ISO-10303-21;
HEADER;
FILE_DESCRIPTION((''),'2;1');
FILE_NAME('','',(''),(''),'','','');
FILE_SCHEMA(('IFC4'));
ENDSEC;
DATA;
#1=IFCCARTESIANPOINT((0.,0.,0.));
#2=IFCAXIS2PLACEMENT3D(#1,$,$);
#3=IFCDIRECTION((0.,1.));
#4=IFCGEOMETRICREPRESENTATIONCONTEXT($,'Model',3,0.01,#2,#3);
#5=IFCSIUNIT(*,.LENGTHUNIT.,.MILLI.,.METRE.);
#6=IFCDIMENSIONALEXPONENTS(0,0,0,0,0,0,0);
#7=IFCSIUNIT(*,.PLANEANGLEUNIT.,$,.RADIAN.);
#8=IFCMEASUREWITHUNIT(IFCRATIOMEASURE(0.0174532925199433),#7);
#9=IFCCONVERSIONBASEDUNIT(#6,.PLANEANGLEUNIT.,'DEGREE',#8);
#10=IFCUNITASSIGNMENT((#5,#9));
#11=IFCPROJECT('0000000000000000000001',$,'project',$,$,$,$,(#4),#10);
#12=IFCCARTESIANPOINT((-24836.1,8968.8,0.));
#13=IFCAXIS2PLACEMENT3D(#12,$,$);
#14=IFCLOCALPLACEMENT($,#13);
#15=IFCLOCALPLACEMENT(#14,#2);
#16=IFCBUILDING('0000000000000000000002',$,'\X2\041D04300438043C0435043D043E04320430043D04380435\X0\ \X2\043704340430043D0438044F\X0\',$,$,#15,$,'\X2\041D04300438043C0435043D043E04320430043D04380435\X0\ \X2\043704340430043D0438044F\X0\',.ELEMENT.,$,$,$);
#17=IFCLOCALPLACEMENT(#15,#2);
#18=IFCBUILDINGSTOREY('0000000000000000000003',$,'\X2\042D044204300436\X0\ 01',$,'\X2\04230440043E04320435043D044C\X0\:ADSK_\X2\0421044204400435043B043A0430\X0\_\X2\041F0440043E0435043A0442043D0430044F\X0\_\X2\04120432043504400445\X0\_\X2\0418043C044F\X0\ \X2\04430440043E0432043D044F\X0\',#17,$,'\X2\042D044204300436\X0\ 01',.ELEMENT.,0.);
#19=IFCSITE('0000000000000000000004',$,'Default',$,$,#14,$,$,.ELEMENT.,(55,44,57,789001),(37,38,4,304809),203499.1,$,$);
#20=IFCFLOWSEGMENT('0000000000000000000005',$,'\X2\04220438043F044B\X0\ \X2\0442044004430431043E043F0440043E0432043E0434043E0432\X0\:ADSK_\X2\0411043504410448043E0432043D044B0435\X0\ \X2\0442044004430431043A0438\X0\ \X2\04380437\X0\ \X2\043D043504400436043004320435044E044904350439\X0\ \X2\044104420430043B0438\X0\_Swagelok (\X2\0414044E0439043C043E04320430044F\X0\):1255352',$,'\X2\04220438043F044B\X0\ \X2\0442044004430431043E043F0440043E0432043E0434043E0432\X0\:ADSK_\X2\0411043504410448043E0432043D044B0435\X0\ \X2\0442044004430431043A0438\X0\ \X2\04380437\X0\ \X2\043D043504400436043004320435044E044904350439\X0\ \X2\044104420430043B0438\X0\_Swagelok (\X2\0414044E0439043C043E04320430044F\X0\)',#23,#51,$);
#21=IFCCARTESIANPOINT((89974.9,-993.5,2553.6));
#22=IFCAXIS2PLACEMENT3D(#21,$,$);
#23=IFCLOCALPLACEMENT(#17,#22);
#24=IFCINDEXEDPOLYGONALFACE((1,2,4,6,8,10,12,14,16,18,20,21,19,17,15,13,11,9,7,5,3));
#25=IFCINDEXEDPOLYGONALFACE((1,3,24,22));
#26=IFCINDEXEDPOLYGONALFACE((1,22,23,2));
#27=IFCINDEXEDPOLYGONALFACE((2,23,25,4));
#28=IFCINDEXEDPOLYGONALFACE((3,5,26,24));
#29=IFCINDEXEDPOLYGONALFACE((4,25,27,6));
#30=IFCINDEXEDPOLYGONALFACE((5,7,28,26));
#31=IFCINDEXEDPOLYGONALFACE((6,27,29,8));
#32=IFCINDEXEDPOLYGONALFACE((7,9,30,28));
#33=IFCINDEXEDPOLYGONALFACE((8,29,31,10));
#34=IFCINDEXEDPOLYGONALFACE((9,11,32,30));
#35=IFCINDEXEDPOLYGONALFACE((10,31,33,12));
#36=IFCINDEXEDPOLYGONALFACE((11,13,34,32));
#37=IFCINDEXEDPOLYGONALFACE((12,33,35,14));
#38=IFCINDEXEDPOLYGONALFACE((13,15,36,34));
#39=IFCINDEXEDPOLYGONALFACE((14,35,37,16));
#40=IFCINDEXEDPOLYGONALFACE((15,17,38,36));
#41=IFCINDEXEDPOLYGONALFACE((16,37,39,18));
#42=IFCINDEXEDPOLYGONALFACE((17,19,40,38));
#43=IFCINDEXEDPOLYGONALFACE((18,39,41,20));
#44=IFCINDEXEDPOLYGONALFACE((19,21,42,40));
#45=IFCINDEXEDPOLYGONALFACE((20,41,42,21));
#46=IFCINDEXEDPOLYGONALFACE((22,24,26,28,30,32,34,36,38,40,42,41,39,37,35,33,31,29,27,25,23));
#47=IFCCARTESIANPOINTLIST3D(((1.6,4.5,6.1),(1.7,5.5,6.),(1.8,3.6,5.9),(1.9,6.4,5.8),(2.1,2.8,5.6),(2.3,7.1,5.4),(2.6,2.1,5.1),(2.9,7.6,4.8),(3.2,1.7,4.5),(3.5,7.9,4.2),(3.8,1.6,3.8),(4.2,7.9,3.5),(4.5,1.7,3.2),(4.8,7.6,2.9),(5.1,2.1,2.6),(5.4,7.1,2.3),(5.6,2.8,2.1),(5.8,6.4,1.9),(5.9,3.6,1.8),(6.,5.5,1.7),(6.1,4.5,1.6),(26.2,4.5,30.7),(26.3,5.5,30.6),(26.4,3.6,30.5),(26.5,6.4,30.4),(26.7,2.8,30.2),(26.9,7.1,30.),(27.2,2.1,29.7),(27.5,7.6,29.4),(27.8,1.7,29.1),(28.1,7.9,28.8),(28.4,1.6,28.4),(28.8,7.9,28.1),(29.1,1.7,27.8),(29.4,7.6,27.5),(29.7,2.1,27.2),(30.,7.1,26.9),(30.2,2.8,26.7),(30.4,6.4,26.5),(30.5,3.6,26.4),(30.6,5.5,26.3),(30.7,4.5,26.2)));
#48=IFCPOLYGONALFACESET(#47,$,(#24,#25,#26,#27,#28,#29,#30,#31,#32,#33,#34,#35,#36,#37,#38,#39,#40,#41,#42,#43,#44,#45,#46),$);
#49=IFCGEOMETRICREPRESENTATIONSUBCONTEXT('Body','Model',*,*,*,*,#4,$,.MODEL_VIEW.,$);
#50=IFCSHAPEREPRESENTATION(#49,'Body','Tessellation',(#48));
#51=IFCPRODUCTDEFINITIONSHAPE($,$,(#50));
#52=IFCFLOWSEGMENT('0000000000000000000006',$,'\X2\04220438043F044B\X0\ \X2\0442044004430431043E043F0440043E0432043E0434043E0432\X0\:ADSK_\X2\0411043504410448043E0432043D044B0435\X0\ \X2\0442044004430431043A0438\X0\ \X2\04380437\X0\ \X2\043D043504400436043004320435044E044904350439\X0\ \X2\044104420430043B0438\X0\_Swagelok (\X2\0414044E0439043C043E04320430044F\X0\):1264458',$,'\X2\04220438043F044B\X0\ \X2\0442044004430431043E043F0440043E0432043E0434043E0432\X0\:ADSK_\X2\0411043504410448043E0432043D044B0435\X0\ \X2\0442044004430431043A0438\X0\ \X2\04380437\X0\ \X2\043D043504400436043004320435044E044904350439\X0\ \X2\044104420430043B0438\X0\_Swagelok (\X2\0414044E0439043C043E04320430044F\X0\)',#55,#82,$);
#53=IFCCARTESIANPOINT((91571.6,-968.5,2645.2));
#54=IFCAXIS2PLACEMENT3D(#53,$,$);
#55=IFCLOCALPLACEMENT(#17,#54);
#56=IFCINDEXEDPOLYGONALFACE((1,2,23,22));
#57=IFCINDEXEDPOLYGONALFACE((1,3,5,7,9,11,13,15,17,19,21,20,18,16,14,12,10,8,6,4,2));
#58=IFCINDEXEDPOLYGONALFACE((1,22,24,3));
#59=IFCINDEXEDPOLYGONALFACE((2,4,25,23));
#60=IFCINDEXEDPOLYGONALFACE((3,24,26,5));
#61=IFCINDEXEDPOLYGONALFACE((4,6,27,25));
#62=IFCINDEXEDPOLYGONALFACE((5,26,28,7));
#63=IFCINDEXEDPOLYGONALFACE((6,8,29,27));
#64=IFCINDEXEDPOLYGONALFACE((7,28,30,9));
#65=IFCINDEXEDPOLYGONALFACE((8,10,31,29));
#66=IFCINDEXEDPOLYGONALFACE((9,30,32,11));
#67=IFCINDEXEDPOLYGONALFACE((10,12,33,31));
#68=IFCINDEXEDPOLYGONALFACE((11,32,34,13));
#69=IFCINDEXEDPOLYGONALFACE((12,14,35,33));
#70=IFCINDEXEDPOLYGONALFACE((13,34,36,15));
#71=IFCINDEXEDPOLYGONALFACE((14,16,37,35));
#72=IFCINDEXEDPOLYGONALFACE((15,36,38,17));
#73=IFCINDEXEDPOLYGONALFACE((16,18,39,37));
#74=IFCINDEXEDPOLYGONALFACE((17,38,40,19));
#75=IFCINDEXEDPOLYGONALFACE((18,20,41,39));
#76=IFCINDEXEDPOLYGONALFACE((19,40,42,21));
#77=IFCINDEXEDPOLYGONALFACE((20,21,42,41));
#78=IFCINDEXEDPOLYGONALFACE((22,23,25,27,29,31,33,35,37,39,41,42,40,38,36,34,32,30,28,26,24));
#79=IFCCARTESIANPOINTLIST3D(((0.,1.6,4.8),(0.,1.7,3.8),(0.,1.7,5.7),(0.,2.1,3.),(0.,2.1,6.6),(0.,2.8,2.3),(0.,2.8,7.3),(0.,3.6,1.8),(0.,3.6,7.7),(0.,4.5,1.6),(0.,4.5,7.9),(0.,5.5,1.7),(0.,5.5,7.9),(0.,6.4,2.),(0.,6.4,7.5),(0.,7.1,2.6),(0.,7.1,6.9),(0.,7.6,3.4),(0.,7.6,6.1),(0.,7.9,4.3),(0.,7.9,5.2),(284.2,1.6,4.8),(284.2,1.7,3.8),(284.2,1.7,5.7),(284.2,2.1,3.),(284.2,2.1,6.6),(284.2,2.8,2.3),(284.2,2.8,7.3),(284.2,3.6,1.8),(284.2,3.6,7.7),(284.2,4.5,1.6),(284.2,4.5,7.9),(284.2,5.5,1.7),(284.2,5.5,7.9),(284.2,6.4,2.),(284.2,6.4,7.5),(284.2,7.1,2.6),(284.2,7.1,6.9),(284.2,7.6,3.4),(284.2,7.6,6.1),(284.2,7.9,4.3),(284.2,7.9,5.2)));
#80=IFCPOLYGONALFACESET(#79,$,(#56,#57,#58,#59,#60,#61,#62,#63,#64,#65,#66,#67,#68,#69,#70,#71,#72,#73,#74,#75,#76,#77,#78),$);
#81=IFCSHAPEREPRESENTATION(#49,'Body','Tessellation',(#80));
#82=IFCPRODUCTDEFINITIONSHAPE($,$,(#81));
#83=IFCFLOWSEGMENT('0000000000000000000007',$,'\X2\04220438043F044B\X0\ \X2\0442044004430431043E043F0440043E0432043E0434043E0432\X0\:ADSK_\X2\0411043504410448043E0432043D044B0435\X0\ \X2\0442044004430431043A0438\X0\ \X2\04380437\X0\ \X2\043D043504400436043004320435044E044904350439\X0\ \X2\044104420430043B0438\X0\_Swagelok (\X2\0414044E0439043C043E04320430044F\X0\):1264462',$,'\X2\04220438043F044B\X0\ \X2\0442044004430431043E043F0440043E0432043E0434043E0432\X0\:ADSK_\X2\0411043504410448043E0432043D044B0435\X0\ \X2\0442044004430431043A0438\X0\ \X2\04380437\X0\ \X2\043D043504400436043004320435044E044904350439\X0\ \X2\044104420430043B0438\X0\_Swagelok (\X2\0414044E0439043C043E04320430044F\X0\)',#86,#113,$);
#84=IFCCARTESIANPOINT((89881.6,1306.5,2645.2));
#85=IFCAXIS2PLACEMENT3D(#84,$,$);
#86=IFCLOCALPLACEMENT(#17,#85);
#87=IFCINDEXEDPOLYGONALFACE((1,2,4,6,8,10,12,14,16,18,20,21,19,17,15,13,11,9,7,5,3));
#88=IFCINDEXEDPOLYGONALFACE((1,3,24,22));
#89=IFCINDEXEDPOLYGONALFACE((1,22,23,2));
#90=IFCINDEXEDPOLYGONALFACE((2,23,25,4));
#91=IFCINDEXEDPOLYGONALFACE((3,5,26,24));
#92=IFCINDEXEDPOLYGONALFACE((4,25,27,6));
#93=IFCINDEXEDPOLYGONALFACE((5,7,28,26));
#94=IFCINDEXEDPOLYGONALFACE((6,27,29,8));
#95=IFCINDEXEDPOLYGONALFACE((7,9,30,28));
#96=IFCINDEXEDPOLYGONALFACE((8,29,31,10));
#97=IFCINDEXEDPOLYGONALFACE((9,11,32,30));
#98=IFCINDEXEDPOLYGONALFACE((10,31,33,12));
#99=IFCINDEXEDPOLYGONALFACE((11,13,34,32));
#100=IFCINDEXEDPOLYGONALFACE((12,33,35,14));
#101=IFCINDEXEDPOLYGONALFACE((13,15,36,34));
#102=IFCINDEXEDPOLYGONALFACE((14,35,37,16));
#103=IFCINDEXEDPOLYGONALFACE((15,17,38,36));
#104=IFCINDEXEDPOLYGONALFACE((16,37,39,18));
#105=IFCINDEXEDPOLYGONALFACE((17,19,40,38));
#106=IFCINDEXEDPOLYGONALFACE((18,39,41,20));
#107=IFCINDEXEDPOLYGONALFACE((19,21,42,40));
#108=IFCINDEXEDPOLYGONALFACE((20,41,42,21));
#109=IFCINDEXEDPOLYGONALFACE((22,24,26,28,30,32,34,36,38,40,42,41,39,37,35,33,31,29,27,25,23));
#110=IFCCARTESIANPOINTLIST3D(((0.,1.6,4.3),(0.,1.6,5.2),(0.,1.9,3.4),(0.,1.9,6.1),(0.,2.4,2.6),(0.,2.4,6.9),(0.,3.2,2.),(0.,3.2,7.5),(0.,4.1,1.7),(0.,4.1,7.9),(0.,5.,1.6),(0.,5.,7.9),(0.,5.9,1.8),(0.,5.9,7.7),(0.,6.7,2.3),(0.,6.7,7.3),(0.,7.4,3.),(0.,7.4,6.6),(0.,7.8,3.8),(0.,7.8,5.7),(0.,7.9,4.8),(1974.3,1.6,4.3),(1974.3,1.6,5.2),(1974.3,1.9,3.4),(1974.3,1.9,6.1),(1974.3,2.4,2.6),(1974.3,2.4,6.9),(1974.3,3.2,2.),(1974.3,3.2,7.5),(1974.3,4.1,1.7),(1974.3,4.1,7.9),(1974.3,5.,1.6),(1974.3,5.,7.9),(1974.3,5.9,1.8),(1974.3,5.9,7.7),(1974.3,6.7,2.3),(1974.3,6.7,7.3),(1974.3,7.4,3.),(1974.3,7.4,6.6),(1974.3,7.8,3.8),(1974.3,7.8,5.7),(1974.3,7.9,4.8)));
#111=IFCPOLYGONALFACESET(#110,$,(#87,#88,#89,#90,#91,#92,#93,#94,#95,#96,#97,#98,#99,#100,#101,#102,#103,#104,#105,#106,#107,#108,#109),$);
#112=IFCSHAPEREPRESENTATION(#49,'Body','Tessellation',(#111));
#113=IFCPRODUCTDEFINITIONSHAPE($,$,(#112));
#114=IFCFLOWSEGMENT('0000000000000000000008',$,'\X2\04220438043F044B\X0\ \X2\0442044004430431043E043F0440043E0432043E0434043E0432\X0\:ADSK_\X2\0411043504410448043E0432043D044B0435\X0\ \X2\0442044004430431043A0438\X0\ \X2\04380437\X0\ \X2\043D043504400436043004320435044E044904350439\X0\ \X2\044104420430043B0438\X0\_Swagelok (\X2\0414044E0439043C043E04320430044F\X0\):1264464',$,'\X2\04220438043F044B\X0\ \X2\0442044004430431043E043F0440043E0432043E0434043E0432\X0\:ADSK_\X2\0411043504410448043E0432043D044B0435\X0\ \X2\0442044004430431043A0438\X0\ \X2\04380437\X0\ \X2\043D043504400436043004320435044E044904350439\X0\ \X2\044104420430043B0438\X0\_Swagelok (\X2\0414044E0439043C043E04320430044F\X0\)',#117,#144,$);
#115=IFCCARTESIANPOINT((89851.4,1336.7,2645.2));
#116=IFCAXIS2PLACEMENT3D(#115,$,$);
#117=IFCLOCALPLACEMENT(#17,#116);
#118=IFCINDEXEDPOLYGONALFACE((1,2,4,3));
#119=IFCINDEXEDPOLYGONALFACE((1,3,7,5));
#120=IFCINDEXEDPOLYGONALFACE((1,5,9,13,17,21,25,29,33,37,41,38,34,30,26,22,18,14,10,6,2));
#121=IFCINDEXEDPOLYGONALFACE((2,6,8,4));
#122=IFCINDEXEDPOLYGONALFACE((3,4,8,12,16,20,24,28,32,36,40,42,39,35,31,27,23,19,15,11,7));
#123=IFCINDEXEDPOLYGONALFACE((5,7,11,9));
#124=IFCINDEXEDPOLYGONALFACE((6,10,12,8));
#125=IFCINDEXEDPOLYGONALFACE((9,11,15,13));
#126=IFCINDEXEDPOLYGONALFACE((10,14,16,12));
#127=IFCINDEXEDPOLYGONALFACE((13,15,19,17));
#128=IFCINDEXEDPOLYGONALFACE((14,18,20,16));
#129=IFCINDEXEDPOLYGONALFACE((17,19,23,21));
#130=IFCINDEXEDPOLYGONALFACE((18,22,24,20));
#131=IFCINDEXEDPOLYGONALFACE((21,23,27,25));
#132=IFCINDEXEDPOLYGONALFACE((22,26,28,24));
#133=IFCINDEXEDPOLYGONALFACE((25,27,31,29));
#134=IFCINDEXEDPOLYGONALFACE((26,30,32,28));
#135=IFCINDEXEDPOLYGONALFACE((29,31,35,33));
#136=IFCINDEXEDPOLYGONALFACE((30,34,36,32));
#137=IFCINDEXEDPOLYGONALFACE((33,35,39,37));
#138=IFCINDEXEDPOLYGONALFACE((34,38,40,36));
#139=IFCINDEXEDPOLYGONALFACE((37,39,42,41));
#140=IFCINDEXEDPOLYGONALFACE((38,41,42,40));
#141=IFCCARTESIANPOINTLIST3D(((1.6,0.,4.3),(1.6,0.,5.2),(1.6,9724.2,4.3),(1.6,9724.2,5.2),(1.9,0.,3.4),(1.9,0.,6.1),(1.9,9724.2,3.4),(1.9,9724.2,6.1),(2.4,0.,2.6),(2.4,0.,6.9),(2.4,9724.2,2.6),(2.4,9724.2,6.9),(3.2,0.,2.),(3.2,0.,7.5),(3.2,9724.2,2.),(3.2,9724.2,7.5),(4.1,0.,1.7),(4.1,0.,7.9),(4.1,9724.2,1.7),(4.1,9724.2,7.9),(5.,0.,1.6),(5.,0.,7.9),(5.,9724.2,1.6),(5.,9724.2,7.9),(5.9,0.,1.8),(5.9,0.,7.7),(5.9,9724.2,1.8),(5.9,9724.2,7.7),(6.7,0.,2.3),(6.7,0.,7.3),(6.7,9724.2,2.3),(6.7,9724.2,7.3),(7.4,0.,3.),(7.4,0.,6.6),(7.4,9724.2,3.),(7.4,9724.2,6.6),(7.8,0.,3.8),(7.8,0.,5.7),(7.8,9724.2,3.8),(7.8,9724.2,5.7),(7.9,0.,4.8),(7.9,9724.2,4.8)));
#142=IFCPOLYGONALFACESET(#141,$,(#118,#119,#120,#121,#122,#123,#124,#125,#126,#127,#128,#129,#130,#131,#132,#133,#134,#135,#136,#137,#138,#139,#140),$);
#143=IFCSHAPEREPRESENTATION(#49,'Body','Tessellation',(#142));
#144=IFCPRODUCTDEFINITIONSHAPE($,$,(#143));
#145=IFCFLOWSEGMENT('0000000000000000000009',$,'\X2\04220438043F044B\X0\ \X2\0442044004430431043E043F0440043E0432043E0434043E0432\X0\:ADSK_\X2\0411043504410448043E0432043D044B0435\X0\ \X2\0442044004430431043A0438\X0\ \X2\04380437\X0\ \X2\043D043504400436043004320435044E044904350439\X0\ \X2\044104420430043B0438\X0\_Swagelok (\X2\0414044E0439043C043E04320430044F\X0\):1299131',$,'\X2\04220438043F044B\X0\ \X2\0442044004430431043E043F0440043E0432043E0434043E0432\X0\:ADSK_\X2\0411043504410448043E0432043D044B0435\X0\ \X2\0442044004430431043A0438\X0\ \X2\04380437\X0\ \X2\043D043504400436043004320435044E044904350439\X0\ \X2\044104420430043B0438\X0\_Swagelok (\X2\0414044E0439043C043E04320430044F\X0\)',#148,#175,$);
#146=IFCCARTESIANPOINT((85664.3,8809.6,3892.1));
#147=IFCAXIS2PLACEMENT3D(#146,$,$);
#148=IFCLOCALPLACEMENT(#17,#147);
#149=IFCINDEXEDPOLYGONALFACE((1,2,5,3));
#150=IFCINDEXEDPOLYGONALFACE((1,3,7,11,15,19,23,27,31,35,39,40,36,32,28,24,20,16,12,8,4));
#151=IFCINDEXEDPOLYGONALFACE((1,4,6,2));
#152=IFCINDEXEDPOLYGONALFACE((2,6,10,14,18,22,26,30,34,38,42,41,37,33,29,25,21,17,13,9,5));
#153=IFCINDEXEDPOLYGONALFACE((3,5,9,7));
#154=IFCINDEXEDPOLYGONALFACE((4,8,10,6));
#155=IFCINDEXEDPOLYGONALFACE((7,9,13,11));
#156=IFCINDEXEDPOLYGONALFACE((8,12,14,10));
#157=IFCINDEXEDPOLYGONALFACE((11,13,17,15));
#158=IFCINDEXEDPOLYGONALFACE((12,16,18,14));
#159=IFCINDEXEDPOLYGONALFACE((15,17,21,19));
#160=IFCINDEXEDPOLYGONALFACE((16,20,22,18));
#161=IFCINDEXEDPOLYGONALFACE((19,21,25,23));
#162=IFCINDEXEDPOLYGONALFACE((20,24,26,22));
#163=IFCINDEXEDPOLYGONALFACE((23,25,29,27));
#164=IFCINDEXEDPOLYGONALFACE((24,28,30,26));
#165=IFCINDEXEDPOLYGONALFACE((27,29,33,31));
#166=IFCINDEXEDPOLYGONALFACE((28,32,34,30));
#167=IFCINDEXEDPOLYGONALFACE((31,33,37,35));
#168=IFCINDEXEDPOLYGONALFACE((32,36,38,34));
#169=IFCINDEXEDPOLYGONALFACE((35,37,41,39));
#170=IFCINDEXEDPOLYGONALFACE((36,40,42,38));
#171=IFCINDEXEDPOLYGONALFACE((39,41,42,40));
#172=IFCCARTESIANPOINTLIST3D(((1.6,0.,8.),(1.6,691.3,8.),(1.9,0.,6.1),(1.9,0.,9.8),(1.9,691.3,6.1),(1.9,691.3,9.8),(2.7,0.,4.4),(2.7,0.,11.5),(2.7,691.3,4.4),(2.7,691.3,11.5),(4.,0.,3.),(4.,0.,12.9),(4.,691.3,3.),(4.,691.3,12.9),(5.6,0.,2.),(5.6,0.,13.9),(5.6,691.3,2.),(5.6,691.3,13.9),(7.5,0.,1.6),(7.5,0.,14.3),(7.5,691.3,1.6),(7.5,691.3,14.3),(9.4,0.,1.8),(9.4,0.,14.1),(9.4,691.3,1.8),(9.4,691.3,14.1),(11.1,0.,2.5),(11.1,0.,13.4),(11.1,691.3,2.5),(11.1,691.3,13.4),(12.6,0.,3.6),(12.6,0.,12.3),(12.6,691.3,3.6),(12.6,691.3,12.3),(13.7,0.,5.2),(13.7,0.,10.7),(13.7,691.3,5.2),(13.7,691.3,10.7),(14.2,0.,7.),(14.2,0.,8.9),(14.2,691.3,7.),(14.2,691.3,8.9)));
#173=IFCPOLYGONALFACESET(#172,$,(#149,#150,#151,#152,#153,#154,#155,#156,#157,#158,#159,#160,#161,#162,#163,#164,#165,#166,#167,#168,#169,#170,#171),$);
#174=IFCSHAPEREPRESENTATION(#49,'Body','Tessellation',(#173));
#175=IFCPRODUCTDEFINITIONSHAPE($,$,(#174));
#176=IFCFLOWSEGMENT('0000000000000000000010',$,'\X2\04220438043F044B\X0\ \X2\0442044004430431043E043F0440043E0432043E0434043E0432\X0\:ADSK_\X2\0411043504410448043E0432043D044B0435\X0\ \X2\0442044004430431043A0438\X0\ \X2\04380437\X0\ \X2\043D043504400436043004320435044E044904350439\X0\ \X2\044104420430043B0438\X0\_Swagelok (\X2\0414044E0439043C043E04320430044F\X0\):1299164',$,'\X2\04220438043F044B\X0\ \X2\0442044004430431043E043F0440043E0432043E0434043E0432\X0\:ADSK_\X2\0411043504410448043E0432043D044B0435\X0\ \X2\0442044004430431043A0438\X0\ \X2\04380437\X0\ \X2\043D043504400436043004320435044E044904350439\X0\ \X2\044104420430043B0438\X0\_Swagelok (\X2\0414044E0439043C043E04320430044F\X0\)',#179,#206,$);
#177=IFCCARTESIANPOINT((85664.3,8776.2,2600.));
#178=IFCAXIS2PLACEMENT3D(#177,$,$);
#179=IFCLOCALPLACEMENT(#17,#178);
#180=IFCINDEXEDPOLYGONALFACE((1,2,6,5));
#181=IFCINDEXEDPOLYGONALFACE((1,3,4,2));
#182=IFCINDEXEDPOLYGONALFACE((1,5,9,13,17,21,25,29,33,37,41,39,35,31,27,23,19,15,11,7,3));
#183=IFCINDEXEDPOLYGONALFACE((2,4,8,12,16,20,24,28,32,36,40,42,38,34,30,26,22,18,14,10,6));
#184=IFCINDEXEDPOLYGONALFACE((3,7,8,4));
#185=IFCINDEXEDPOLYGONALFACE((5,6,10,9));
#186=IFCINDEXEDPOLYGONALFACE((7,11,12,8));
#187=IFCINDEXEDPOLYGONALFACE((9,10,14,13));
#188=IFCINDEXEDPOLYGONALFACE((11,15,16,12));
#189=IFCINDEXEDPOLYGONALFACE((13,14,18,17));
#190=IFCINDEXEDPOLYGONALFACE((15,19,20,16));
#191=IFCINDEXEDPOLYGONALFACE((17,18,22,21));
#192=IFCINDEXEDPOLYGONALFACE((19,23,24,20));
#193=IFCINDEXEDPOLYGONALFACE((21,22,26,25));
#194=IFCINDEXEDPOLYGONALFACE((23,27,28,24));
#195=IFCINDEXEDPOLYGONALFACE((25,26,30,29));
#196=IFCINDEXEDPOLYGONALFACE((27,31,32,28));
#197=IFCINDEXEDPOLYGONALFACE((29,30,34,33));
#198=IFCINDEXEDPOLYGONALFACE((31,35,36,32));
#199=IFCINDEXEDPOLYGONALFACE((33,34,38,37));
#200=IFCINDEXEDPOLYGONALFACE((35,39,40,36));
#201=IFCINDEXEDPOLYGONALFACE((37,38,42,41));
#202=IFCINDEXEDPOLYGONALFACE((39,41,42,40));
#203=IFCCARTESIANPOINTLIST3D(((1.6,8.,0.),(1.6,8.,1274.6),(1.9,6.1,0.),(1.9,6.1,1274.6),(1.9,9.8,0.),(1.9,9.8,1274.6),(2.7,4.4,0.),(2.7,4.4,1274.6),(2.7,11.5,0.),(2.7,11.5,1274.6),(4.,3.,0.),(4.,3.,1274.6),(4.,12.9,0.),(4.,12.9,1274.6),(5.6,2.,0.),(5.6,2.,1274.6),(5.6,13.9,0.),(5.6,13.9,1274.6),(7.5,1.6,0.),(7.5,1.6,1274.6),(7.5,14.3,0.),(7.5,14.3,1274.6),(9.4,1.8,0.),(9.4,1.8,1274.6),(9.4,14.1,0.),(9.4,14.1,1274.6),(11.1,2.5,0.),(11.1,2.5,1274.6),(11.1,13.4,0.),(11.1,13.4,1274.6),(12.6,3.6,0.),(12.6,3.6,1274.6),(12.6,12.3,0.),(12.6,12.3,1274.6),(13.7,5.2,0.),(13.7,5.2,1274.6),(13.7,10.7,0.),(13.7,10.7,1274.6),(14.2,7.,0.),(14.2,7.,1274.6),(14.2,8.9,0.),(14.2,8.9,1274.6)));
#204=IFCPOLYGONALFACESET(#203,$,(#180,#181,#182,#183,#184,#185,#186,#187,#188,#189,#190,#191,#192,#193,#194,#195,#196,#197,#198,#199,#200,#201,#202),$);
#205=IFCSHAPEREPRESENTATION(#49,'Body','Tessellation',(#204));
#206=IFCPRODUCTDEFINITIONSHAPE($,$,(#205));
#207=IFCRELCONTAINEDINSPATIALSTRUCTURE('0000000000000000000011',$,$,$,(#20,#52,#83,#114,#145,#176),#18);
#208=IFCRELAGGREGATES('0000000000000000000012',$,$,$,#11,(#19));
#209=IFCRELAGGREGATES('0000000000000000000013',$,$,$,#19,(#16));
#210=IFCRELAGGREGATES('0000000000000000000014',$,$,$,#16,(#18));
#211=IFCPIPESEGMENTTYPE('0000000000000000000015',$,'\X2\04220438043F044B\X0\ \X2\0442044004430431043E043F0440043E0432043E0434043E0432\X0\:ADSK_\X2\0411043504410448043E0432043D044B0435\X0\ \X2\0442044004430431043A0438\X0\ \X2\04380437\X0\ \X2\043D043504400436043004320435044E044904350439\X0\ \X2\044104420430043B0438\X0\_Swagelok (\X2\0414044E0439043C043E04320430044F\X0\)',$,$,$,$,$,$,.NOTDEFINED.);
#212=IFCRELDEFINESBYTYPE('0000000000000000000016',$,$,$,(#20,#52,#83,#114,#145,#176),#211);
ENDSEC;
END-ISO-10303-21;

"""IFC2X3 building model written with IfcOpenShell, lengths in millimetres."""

from ifc_helpers import new_model, entity, si_unit, converted_unit, direction, frame, origin, origin_2d_with_axis, place, context, subcontext, project, spatial, circle, extrude, type_object, element, save


model = new_model("IFC2X3")

# Units and contexts
model_context = context("Model", 3, precision=0.01, world=origin(), true_north=direction((0.0, 1.0)))
body_context = subcontext(model_context, "Body", "Model", "MODEL_VIEW")
ifc_project = project(units=[si_unit("LENGTHUNIT", "METRE", prefix="MILLI"), converted_unit("PLANEANGLEUNIT", "DEGREE", entity("IfcRatioMeasure", 0.0174532925199433), si_unit("PLANEANGLEUNIT", "RADIAN"), dimensions=[0, 0, 0, 0, 0, 0, 0])], contexts=[model_context])

# Site, building, storey
site_placement = place(None, frame((-24836.1, 8968.8, 0.0)))
site = spatial("IfcSite", under=ifc_project, at=site_placement, Name="Default", CompositionType="ELEMENT", RefLatitude=(55, 44, 57, 789001), RefLongitude=(37, 38, 4, 304809), RefElevation=203499.1)
building_placement = place(site_placement, origin())
building = spatial("IfcBuilding", under=site, at=building_placement, Name="Наименование здания", LongName="Наименование здания", CompositionType="ELEMENT")
storey_placement = place(building_placement, origin())
storey = spatial("IfcBuildingStorey", under=building, at=storey_placement, Name="Этаж 01", ObjectType="Уровень:ADSK_Стрелка_Проектная_Вверх_Имя уровня", LongName="Этаж 01", CompositionType="ELEMENT", Elevation=0.0)

# Flow segments
pipe_segment_type_1 = type_object("IfcPipeSegmentType", Name="Типы трубопроводов:ADSK_Бесшовные трубки из нержавеющей стали_Swagelok (Дюймовая)", PredefinedType="NOTDEFINED")
flow_segment_1_placement = place(storey_placement, frame((89974.9, -993.5, 2553.6)))
element("IfcFlowSegment", 1, at=flow_segment_1_placement, inside=storey, type_object=pipe_segment_type_1, Name="Типы трубопроводов:ADSK_Бесшовные трубки из нержавеющей стали_Swagelok (Дюймовая):1255352", ObjectType="Типы трубопроводов:ADSK_Бесшовные трубки из нержавеющей стали_Swagelok (Дюймовая)", context=body_context, shape_type="SweptSolid", body=[
    extrude(circle(Radius=3.2, at=origin_2d_with_axis()), frame((3.8, 4.8, 3.8), z_axis=(0.707107, 0.0, 0.707107), x_axis=(0.0, -1.0, 0.0)), (0.0, 0.0, 1.0), 34.8),
])
flow_segment_2_placement = place(storey_placement, frame((91571.6, -968.5, 2645.2)))
element("IfcFlowSegment", 2, at=flow_segment_2_placement, inside=storey, type_object=pipe_segment_type_1, Name="Типы трубопроводов:ADSK_Бесшовные трубки из нержавеющей стали_Swagelok (Дюймовая):1264458", ObjectType="Типы трубопроводов:ADSK_Бесшовные трубки из нержавеющей стали_Swagelok (Дюймовая)", context=body_context, shape_type="SweptSolid", body=[
    extrude(circle(Radius=3.2, at=origin_2d_with_axis()), frame((0.0, 4.8, 4.8), z_axis=(1.0, 0.0, 0.0), x_axis=(0.0, -1.0, 0.0)), (0.0, 0.0, 1.0), 284.2),
])
flow_segment_3_placement = place(storey_placement, frame((89881.6, 1306.5, 2645.2)))
element("IfcFlowSegment", 3, at=flow_segment_3_placement, inside=storey, type_object=pipe_segment_type_1, Name="Типы трубопроводов:ADSK_Бесшовные трубки из нержавеющей стали_Swagelok (Дюймовая):1264462", ObjectType="Типы трубопроводов:ADSK_Бесшовные трубки из нержавеющей стали_Swagelok (Дюймовая)", context=body_context, shape_type="SweptSolid", body=[
    extrude(circle(Radius=3.2, at=origin_2d_with_axis()), frame((0.0, 4.8, 4.8), z_axis=(1.0, 0.0, 0.0), x_axis=(0.0, 1.0, 0.0)), (0.0, 0.0, 1.0), 1974.3),
])
flow_segment_4_placement = place(storey_placement, frame((89851.4, 1336.7, 2645.2)))
element("IfcFlowSegment", 4, at=flow_segment_4_placement, inside=storey, type_object=pipe_segment_type_1, Name="Типы трубопроводов:ADSK_Бесшовные трубки из нержавеющей стали_Swagelok (Дюймовая):1264464", ObjectType="Типы трубопроводов:ADSK_Бесшовные трубки из нержавеющей стали_Swagelok (Дюймовая)", context=body_context, shape_type="SweptSolid", body=[
    extrude(circle(Radius=3.2, at=origin_2d_with_axis()), frame((4.8, 0.0, 4.8), z_axis=(0.0, 1.0, 0.0), x_axis=(1.0, 0.0, 0.0)), (0.0, 0.0, 1.0), 9724.2),
])
flow_segment_5_placement = place(storey_placement, frame((85664.3, 8809.6, 3892.1)))
element("IfcFlowSegment", 5, at=flow_segment_5_placement, inside=storey, type_object=pipe_segment_type_1, Name="Типы трубопроводов:ADSK_Бесшовные трубки из нержавеющей стали_Swagelok (Дюймовая):1299131", ObjectType="Типы трубопроводов:ADSK_Бесшовные трубки из нержавеющей стали_Swagelok (Дюймовая)", context=body_context, shape_type="SweptSolid", body=[
    extrude(circle(Radius=6.3, at=origin_2d_with_axis()), frame((8.0, 0.0, 8.0), z_axis=(0.0, 1.0, 0.0), x_axis=(-1.0, 0.0, 0.0)), (0.0, 0.0, 1.0), 691.3),
])
flow_segment_6_placement = place(storey_placement, frame((85664.3, 8776.2, 2600.0)))
element("IfcFlowSegment", 6, at=flow_segment_6_placement, inside=storey, type_object=pipe_segment_type_1, Name="Типы трубопроводов:ADSK_Бесшовные трубки из нержавеющей стали_Swagelok (Дюймовая):1299164", ObjectType="Типы трубопроводов:ADSK_Бесшовные трубки из нержавеющей стали_Swagelok (Дюймовая)", context=body_context, shape_type="SweptSolid", body=[
    extrude(circle(Radius=6.3, at=origin_2d_with_axis()), frame((8.0, 8.0, 0.0), z_axis=(0.0, 0.0, 1.0), x_axis=(-1.0, 0.0, 0.0)), (0.0, 0.0, 1.0), 1274.6),
])

save(model, "model.ifc")
